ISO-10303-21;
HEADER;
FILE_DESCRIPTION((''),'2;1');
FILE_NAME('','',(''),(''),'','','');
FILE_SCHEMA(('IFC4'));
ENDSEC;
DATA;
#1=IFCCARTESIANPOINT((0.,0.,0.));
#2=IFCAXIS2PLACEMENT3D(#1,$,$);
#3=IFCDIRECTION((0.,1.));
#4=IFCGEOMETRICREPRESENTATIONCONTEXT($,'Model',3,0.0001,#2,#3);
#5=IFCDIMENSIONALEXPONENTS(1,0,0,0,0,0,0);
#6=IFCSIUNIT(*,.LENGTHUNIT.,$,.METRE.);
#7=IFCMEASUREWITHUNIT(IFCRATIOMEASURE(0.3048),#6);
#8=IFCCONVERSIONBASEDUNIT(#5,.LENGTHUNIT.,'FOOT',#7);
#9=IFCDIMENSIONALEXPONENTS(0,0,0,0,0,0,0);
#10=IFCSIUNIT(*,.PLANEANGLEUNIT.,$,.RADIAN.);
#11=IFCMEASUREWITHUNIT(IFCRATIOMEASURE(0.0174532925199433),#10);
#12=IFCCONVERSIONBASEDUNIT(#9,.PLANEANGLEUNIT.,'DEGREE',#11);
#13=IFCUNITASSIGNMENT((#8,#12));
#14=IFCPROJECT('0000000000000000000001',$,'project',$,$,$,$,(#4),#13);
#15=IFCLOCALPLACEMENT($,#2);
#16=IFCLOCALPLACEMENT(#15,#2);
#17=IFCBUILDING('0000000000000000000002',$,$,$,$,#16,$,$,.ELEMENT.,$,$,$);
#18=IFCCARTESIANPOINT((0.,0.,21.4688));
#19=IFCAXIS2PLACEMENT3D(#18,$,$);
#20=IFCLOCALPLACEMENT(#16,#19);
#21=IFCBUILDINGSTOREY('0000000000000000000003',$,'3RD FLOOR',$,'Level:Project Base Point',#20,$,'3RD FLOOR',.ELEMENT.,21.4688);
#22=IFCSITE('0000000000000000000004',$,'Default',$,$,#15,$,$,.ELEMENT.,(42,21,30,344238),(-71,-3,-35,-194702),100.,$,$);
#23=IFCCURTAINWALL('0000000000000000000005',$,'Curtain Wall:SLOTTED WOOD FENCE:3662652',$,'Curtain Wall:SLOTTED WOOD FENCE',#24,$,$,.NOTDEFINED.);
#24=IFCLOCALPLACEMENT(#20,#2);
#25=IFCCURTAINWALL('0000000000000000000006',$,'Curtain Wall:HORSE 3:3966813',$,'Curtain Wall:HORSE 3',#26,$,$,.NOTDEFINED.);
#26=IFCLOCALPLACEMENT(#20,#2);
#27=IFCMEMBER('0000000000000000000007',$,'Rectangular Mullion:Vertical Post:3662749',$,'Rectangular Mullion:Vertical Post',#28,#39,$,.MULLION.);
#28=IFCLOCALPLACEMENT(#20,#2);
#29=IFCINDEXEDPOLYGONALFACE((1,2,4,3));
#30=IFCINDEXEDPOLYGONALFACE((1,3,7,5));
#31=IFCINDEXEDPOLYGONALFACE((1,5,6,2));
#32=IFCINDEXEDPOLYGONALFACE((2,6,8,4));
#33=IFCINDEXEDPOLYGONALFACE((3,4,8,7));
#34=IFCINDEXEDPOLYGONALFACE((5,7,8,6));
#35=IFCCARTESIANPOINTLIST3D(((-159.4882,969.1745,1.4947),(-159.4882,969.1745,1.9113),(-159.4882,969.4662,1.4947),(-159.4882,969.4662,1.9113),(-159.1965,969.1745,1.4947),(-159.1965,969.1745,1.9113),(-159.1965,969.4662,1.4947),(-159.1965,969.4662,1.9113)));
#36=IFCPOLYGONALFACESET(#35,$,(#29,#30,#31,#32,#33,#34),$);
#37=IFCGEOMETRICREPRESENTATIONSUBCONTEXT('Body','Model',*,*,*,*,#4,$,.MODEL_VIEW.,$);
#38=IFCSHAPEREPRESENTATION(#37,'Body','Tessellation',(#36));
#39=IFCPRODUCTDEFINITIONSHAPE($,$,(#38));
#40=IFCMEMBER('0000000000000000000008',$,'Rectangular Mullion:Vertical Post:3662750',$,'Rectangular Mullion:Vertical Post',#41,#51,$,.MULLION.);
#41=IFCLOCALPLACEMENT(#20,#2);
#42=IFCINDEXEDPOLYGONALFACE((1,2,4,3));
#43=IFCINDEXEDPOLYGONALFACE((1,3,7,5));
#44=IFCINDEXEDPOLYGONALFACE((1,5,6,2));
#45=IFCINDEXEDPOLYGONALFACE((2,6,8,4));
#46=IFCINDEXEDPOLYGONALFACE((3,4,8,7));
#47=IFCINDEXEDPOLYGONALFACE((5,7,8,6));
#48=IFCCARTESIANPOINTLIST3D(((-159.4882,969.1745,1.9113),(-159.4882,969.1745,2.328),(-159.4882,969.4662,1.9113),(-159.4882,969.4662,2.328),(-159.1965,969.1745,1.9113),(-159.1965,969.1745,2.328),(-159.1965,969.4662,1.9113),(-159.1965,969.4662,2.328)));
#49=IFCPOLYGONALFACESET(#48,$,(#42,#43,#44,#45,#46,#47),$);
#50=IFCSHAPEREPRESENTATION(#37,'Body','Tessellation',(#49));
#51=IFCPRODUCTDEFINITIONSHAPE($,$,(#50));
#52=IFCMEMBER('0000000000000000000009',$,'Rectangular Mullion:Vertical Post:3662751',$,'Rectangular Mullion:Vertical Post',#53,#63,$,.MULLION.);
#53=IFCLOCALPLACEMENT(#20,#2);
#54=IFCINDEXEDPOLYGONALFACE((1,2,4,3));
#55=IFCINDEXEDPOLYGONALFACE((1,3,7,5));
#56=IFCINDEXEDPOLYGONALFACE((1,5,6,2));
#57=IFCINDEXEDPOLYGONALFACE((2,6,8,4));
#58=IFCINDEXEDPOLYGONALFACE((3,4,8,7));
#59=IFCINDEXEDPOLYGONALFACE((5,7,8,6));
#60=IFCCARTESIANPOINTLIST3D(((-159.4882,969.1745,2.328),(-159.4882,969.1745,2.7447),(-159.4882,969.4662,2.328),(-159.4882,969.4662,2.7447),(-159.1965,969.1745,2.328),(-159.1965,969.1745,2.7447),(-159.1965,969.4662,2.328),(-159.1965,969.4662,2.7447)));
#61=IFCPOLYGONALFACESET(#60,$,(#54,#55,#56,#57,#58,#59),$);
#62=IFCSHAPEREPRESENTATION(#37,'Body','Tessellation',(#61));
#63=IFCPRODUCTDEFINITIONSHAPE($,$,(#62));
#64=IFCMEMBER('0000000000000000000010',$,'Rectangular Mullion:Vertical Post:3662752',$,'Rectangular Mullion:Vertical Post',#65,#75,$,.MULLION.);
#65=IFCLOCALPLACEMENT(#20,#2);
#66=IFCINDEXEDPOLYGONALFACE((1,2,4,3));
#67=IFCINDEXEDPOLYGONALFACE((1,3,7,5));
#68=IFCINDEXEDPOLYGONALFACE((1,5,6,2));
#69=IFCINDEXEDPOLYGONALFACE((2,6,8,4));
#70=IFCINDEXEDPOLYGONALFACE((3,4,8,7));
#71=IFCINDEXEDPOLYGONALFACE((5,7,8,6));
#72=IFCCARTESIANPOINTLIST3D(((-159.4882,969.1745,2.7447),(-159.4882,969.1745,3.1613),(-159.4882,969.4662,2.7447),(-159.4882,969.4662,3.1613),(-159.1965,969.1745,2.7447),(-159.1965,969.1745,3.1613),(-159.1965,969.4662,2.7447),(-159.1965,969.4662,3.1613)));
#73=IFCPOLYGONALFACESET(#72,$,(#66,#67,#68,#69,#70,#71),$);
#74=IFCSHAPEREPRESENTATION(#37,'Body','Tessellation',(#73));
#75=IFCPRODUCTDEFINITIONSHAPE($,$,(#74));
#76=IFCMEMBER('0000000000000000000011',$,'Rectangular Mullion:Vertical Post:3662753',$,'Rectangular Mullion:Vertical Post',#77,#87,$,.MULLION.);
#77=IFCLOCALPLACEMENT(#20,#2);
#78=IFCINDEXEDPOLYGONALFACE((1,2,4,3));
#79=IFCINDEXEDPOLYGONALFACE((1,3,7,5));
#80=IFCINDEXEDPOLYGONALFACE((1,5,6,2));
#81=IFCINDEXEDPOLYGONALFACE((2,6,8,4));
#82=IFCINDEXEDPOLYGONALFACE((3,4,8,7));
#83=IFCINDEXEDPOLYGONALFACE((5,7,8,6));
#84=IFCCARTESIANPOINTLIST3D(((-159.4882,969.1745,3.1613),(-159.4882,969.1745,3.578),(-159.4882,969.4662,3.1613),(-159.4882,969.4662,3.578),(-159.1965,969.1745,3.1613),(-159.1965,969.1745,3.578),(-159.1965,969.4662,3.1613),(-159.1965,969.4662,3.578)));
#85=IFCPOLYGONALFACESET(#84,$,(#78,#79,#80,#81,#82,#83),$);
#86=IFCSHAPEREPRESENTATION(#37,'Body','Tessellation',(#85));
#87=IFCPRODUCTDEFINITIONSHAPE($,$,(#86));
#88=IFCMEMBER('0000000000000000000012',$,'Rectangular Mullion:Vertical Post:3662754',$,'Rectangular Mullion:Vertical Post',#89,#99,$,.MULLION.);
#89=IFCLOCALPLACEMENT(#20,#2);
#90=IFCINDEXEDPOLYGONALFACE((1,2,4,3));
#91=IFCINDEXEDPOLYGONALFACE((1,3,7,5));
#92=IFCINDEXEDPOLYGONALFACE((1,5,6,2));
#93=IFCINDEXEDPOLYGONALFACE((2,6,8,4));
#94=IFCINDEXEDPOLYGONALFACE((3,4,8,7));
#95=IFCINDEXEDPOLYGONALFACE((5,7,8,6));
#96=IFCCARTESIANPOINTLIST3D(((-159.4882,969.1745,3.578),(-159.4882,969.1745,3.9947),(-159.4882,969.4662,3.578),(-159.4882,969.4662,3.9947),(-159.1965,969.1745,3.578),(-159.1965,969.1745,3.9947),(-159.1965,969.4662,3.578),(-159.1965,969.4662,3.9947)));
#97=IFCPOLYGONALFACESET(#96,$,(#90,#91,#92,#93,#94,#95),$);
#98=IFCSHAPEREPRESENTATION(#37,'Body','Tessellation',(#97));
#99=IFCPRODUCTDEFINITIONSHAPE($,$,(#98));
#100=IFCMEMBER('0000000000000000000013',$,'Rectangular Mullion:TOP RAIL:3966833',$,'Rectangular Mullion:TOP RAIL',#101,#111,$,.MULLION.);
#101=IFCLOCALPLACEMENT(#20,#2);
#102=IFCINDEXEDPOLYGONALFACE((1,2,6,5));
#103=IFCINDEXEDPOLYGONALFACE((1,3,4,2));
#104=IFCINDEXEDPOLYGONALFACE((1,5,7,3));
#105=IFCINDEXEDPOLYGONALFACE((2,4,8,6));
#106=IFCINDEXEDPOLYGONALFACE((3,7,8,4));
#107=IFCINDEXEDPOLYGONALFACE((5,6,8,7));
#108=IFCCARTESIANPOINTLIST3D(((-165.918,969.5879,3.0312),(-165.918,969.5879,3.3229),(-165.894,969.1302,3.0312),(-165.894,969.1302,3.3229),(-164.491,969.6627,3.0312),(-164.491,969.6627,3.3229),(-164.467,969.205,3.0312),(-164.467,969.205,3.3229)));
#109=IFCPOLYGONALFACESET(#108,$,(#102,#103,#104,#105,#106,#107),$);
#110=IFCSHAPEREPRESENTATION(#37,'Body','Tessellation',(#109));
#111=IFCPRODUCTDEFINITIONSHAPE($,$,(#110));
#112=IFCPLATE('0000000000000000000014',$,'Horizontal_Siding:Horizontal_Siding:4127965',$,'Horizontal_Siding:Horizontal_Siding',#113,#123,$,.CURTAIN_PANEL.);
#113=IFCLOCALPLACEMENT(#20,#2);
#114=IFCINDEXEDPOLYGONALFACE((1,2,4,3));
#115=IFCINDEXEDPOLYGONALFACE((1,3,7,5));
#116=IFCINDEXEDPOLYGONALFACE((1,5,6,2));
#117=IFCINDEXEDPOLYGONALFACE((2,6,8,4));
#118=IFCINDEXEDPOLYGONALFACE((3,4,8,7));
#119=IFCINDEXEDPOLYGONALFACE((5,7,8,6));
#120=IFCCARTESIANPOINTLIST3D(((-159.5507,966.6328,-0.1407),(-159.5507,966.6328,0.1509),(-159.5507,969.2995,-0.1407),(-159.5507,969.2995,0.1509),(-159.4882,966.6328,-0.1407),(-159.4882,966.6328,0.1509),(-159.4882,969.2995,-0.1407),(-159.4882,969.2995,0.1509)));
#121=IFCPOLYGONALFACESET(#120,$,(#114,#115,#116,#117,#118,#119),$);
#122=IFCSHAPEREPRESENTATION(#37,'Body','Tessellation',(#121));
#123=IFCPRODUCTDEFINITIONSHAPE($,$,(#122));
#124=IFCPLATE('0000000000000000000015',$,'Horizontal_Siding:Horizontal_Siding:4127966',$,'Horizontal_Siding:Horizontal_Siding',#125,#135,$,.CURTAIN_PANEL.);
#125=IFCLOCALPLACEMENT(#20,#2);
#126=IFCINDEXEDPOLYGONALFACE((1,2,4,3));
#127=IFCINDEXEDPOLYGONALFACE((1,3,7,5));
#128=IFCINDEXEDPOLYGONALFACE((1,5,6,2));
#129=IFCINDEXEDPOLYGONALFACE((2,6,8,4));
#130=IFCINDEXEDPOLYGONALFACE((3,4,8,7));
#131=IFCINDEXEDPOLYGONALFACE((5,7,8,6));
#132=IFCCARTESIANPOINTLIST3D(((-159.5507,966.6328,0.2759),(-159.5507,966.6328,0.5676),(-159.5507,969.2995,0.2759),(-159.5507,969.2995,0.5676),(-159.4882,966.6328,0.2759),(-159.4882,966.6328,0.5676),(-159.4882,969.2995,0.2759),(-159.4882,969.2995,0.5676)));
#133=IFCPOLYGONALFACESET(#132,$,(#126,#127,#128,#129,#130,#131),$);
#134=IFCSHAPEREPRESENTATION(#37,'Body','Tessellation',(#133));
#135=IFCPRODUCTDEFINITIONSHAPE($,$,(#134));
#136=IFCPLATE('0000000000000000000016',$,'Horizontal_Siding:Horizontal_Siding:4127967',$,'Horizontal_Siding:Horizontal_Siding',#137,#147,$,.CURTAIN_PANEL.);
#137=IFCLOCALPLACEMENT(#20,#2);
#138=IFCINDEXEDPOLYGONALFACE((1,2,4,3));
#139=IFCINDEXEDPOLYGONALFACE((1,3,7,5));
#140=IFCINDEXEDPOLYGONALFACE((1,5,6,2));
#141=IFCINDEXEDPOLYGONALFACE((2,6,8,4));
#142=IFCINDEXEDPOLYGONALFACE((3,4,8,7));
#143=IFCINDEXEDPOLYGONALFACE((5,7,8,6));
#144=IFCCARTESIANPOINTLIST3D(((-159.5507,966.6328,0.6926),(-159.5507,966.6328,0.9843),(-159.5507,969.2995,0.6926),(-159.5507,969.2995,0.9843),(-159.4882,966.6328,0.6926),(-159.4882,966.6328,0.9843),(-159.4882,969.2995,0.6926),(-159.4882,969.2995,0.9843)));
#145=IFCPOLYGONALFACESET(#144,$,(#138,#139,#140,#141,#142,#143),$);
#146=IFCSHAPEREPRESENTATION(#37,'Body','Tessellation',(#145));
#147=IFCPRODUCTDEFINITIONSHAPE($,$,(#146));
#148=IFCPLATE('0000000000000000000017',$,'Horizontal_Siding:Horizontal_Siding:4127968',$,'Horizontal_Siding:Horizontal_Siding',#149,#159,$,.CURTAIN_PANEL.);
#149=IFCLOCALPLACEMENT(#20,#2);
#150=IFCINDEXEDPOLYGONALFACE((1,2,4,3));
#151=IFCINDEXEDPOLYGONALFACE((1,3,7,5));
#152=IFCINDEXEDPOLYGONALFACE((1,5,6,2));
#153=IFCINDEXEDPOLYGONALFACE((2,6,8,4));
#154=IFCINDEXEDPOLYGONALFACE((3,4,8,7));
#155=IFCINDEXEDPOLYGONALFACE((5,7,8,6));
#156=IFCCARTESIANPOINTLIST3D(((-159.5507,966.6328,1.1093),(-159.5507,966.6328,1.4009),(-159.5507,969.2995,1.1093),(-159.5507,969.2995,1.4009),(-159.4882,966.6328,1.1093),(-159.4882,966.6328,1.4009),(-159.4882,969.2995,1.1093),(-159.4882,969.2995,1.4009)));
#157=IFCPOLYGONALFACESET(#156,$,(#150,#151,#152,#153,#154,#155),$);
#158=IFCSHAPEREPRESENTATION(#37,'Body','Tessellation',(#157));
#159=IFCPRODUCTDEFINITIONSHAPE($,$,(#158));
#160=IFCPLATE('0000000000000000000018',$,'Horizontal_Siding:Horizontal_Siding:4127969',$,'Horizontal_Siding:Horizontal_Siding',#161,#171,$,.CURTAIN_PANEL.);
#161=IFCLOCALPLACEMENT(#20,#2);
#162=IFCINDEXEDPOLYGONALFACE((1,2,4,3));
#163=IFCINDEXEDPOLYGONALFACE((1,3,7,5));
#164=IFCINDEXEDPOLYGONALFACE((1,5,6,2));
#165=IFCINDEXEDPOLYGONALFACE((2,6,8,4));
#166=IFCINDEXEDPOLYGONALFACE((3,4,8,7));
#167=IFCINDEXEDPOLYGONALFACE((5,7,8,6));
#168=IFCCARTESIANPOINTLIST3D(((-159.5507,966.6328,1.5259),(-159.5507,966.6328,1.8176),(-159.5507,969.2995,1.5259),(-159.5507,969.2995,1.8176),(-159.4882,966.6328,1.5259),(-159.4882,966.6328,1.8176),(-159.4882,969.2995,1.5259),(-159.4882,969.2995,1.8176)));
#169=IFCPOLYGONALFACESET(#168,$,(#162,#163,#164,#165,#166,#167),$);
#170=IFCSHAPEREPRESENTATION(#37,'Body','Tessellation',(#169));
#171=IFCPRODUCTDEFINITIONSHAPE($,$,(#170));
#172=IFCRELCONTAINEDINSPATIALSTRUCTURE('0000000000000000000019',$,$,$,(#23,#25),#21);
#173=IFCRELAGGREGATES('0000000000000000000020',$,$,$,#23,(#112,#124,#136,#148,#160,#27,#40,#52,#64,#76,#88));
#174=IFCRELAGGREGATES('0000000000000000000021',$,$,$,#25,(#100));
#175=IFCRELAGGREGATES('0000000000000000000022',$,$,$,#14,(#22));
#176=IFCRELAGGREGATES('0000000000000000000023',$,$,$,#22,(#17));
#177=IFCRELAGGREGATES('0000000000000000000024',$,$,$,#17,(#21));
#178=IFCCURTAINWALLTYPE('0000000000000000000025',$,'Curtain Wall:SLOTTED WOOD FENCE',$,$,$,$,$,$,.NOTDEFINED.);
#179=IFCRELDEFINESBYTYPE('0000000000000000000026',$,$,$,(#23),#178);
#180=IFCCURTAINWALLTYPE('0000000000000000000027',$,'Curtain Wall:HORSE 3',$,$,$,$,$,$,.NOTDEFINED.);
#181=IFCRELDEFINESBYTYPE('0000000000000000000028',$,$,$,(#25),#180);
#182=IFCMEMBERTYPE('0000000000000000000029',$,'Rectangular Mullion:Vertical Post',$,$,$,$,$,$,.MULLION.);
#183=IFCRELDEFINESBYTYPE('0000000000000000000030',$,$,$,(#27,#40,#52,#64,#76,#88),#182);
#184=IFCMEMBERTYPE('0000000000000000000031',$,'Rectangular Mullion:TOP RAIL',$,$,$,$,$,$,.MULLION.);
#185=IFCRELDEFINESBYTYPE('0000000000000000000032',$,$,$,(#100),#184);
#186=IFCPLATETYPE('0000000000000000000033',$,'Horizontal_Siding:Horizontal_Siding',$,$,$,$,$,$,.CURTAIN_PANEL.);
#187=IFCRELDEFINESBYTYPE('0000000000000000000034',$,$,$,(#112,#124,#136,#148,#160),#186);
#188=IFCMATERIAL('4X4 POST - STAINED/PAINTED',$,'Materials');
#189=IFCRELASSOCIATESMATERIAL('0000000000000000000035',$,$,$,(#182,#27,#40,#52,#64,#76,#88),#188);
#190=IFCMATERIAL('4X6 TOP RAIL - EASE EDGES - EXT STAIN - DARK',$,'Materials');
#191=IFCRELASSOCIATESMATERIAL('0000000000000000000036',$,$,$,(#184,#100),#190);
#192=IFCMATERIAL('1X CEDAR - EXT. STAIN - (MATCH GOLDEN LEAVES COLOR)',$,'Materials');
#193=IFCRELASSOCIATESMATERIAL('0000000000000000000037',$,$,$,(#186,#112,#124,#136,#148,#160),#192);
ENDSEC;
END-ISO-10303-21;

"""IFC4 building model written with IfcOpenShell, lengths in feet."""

from ifc_helpers import new_model, entity, si_unit, converted_unit, direction, frame, origin, origin_2d_with_axis, place, context, subcontext, project, spatial, rectangle, extrude, source, transform, mapped, material, material_profile, profile_set, profile_usage, type_object, type_shapes, element, aggregate, save


model = new_model("IFC4")

# Units and contexts
model_context = context("Model", 3, precision=0.0001, world=origin(), true_north=direction((0.0, 1.0)))
body_context = subcontext(model_context, "Body", "Model", "MODEL_VIEW")
ifc_project = project(units=[converted_unit("LENGTHUNIT", "FOOT", entity("IfcRatioMeasure", 0.3048), si_unit("LENGTHUNIT", "METRE"), dimensions=[1, 0, 0, 0, 0, 0, 0]), converted_unit("PLANEANGLEUNIT", "DEGREE", entity("IfcRatioMeasure", 0.0174532925199433), si_unit("PLANEANGLEUNIT", "RADIAN"), dimensions=[0, 0, 0, 0, 0, 0, 0])], contexts=[model_context])

# Site, building, storey
site_placement = place(None, origin())
site = spatial("IfcSite", under=ifc_project, at=site_placement, Name="Default", CompositionType="ELEMENT", RefLatitude=(42, 21, 30, 344238), RefLongitude=(-71, -3, -35, -194702), RefElevation=100.0)
building_placement = place(site_placement, origin())
building = spatial("IfcBuilding", under=site, at=building_placement, CompositionType="ELEMENT")
storey_placement = place(building_placement, frame((0.0, 0.0, 21.4688)))
storey = spatial("IfcBuildingStorey", under=building, at=storey_placement, Name="3RD FLOOR", ObjectType="Level:Project Base Point", LongName="3RD FLOOR", CompositionType="ELEMENT", Elevation=21.4688)

# Curtain wall
curtain_wall_type_1 = type_object("IfcCurtainWallType", Name="Curtain Wall:SLOTTED WOOD FENCE", PredefinedType="NOTDEFINED")
curtain_wall_1_placement = place(storey_placement, frame((0.0, 0.0, -21.4688)))
curtain_wall_1 = element("IfcCurtainWall", 1, at=curtain_wall_1_placement, inside=storey, type_object=curtain_wall_type_1, Name="Curtain Wall:SLOTTED WOOD FENCE:3662652", ObjectType="Curtain Wall:SLOTTED WOOD FENCE", PredefinedType="NOTDEFINED")
ifc_material_1 = material(Name="4X4 POST - STAINED/PAINTED", Category="Materials")
ifc_material_profile_1 = material_profile(ifc_material_1, rectangle(XDim=0.2917, YDim=0.2917, at=origin_2d_with_axis()), Name="Vertical Post")
ifc_profile_set_1 = profile_set([ifc_material_profile_1], Name="Vertical Post")

# Curtain wall
curtain_wall_type_2 = type_object("IfcCurtainWallType", Name="Curtain Wall:HORSE 3", PredefinedType="NOTDEFINED")
curtain_wall_2_placement = place(storey_placement, frame((0.0, 0.0, -21.4688)))
curtain_wall_2 = element("IfcCurtainWall", 2, at=curtain_wall_2_placement, inside=storey, type_object=curtain_wall_type_2, Name="Curtain Wall:HORSE 3:3966813", ObjectType="Curtain Wall:HORSE 3", PredefinedType="NOTDEFINED")

# Members
member_type_1 = type_object("IfcMemberType", Name="Rectangular Mullion:Vertical Post", PredefinedType="MULLION", material=ifc_profile_set_1)
shared_shape_1 = source(origin(), body_context, "Body", "SweptSolid", [
    extrude(rectangle(XDim=0.2917, YDim=0.2917, at=origin_2d_with_axis()), frame((-0.1458, -0.2083, -0.4167), z_axis=(0.0, 0.0, 1.0), x_axis=(0.0, -1.0, 0.0)), (0.0, 0.0, 1.0), 0.4167),
])
type_shapes(member_type_1, [shared_shape_1])
ifc_profile_usage_1 = profile_usage(ifc_profile_set_1)
member_1_placement = place(storey_placement, frame((-159.5507, 969.4662, 1.9113), z_axis=(0.0, 0.0, 1.0), x_axis=(0.0, 1.0, 0.0)))
member_1 = element("IfcMember", 3, at=member_1_placement, type_object=member_type_1, material=ifc_profile_usage_1, Name="Rectangular Mullion:Vertical Post:3662749", ObjectType="Rectangular Mullion:Vertical Post", PredefinedType="MULLION", context=body_context, shape_type="MappedRepresentation", body=[
    mapped(shared_shape_1, transform((0.0, 0.0, 0.0), scale=1.0)),
])
ifc_profile_usage_2 = profile_usage(ifc_profile_set_1)
member_2_placement = place(storey_placement, frame((-159.5507, 969.4662, 2.328), z_axis=(0.0, 0.0, 1.0), x_axis=(0.0, 1.0, 0.0)))
member_2 = element("IfcMember", 4, at=member_2_placement, type_object=member_type_1, material=ifc_profile_usage_2, Name="Rectangular Mullion:Vertical Post:3662750", ObjectType="Rectangular Mullion:Vertical Post", PredefinedType="MULLION", context=body_context, shape_type="MappedRepresentation", body=[
    mapped(shared_shape_1, transform((0.0, 0.0, 0.0), scale=1.0)),
])
ifc_profile_usage_3 = profile_usage(ifc_profile_set_1)
member_3_placement = place(storey_placement, frame((-159.5507, 969.4662, 2.7447), z_axis=(0.0, 0.0, 1.0), x_axis=(0.0, 1.0, 0.0)))
member_3 = element("IfcMember", 5, at=member_3_placement, type_object=member_type_1, material=ifc_profile_usage_3, Name="Rectangular Mullion:Vertical Post:3662751", ObjectType="Rectangular Mullion:Vertical Post", PredefinedType="MULLION", context=body_context, shape_type="MappedRepresentation", body=[
    mapped(shared_shape_1, transform((0.0, 0.0, 0.0), scale=1.0)),
])
ifc_profile_usage_4 = profile_usage(ifc_profile_set_1)
member_4_placement = place(storey_placement, frame((-159.5507, 969.4662, 3.1613), z_axis=(0.0, 0.0, 1.0), x_axis=(0.0, 1.0, 0.0)))
member_4 = element("IfcMember", 6, at=member_4_placement, type_object=member_type_1, material=ifc_profile_usage_4, Name="Rectangular Mullion:Vertical Post:3662752", ObjectType="Rectangular Mullion:Vertical Post", PredefinedType="MULLION", context=body_context, shape_type="MappedRepresentation", body=[
    mapped(shared_shape_1, transform((0.0, 0.0, 0.0), scale=1.0)),
])
ifc_profile_usage_5 = profile_usage(ifc_profile_set_1)
member_5_placement = place(storey_placement, frame((-159.5507, 969.4662, 3.578), z_axis=(0.0, 0.0, 1.0), x_axis=(0.0, 1.0, 0.0)))
member_5 = element("IfcMember", 7, at=member_5_placement, type_object=member_type_1, material=ifc_profile_usage_5, Name="Rectangular Mullion:Vertical Post:3662753", ObjectType="Rectangular Mullion:Vertical Post", PredefinedType="MULLION", context=body_context, shape_type="MappedRepresentation", body=[
    mapped(shared_shape_1, transform((0.0, 0.0, 0.0), scale=1.0)),
])
ifc_profile_usage_6 = profile_usage(ifc_profile_set_1)
member_6_placement = place(storey_placement, frame((-159.5507, 969.4662, 3.9947), z_axis=(0.0, 0.0, 1.0), x_axis=(0.0, 1.0, 0.0)))
member_6 = element("IfcMember", 8, at=member_6_placement, type_object=member_type_1, material=ifc_profile_usage_6, Name="Rectangular Mullion:Vertical Post:3662754", ObjectType="Rectangular Mullion:Vertical Post", PredefinedType="MULLION", context=body_context, shape_type="MappedRepresentation", body=[
    mapped(shared_shape_1, transform((0.0, 0.0, 0.0), scale=1.0)),
])
ifc_material_2 = material(Name="4X6 TOP RAIL - EASE EDGES - EXT STAIN - DARK", Category="Materials")
ifc_material_profile_2 = material_profile(ifc_material_2, rectangle(XDim=0.4583, YDim=0.2917, at=origin_2d_with_axis()), Name="TOP RAIL")
ifc_profile_set_2 = profile_set([ifc_material_profile_2], Name="TOP RAIL")
ifc_profile_usage_7 = profile_usage(ifc_profile_set_2)
member_type_2 = type_object("IfcMemberType", Name="Rectangular Mullion:TOP RAIL", PredefinedType="MULLION", material=ifc_profile_set_2)
shared_shape_2 = source(origin(), body_context, "Body", "SweptSolid", [
    extrude(rectangle(XDim=0.4583, YDim=0.2917, at=origin_2d_with_axis()), frame((-0.1458, 0.0625, -1.429), z_axis=(0.0, 0.0, 1.0), x_axis=(0.0, -1.0, 0.0)), (0.0, 0.0, 1.0), 1.429),
])
type_shapes(member_type_2, [shared_shape_2])
member_7_placement = place(storey_placement, frame((-165.9028, 969.2966, 3.3229), z_axis=(-0.99863, -0.052336, 0.0), x_axis=(0.0, 0.0, 1.0)))
member_7 = element("IfcMember", 9, at=member_7_placement, type_object=member_type_2, material=ifc_profile_usage_7, Name="Rectangular Mullion:TOP RAIL:3966833", ObjectType="Rectangular Mullion:TOP RAIL", PredefinedType="MULLION", context=body_context, shape_type="MappedRepresentation", body=[
    mapped(shared_shape_2, transform((0.0, 0.0, 0.0), scale=1.0)),
])

# Plates
ifc_material_3 = material(Name="1X CEDAR - EXT. STAIN - (MATCH GOLDEN LEAVES COLOR)", Category="Materials")
plate_type_1 = type_object("IfcPlateType", Name="Horizontal_Siding:Horizontal_Siding", PredefinedType="CURTAIN_PANEL", material=ifc_material_3)
shared_shape_3 = source(origin(), body_context, "Body", "SweptSolid", [
    extrude(rectangle(XDim=2.6667, YDim=0.0625, at=origin_2d_with_axis()), frame((1.3333, 0.0312, 0.0), z_axis=(0.0, 0.0, 1.0), x_axis=(-1.0, 0.0, 0.0)), (0.0, 0.0, 1.0), 0.2917),
])
type_shapes(plate_type_1, [shared_shape_3])
plate_1_placement = place(curtain_wall_1_placement, frame((-159.5507, 969.2995, 21.328), z_axis=(0.0, 0.0, 1.0), x_axis=(0.0, -1.0, 0.0)))
plate_1 = element("IfcPlate", 10, at=plate_1_placement, type_object=plate_type_1, material=ifc_material_3, Name="Horizontal_Siding:Horizontal_Siding:4127965", ObjectType="Horizontal_Siding:Horizontal_Siding", PredefinedType="CURTAIN_PANEL", context=body_context, shape_type="MappedRepresentation", body=[
    mapped(shared_shape_3, transform((0.0, 0.0, 0.0), scale=1.0)),
])
plate_2_placement = place(curtain_wall_1_placement, frame((-159.5507, 969.2995, 21.7447), z_axis=(0.0, 0.0, 1.0), x_axis=(0.0, -1.0, 0.0)))
plate_2 = element("IfcPlate", 11, at=plate_2_placement, type_object=plate_type_1, material=ifc_material_3, Name="Horizontal_Siding:Horizontal_Siding:4127966", ObjectType="Horizontal_Siding:Horizontal_Siding", PredefinedType="CURTAIN_PANEL", context=body_context, shape_type="MappedRepresentation", body=[
    mapped(shared_shape_3, transform((0.0, 0.0, 0.0), scale=1.0)),
])
plate_3_placement = place(curtain_wall_1_placement, frame((-159.5507, 969.2995, 22.1613), z_axis=(0.0, 0.0, 1.0), x_axis=(0.0, -1.0, 0.0)))
plate_3 = element("IfcPlate", 12, at=plate_3_placement, type_object=plate_type_1, material=ifc_material_3, Name="Horizontal_Siding:Horizontal_Siding:4127967", ObjectType="Horizontal_Siding:Horizontal_Siding", PredefinedType="CURTAIN_PANEL", context=body_context, shape_type="MappedRepresentation", body=[
    mapped(shared_shape_3, transform((0.0, 0.0, 0.0), scale=1.0)),
])
plate_4_placement = place(curtain_wall_1_placement, frame((-159.5507, 969.2995, 22.578), z_axis=(0.0, 0.0, 1.0), x_axis=(0.0, -1.0, 0.0)))
plate_4 = element("IfcPlate", 13, at=plate_4_placement, type_object=plate_type_1, material=ifc_material_3, Name="Horizontal_Siding:Horizontal_Siding:4127968", ObjectType="Horizontal_Siding:Horizontal_Siding", PredefinedType="CURTAIN_PANEL", context=body_context, shape_type="MappedRepresentation", body=[
    mapped(shared_shape_3, transform((0.0, 0.0, 0.0), scale=1.0)),
])
plate_5_placement = place(curtain_wall_1_placement, frame((-159.5507, 969.2995, 22.9947), z_axis=(0.0, 0.0, 1.0), x_axis=(0.0, -1.0, 0.0)))
plate_5 = element("IfcPlate", 14, at=plate_5_placement, type_object=plate_type_1, material=ifc_material_3, Name="Horizontal_Siding:Horizontal_Siding:4127969", ObjectType="Horizontal_Siding:Horizontal_Siding", PredefinedType="CURTAIN_PANEL", context=body_context, shape_type="MappedRepresentation", body=[
    mapped(shared_shape_3, transform((0.0, 0.0, 0.0), scale=1.0)),
])
aggregate(curtain_wall_1, [plate_1, plate_2, plate_3, plate_4, plate_5, member_1, member_2, member_3, member_4, member_5, member_6])
aggregate(curtain_wall_2, [member_7])

save(model, "model.ifc")
